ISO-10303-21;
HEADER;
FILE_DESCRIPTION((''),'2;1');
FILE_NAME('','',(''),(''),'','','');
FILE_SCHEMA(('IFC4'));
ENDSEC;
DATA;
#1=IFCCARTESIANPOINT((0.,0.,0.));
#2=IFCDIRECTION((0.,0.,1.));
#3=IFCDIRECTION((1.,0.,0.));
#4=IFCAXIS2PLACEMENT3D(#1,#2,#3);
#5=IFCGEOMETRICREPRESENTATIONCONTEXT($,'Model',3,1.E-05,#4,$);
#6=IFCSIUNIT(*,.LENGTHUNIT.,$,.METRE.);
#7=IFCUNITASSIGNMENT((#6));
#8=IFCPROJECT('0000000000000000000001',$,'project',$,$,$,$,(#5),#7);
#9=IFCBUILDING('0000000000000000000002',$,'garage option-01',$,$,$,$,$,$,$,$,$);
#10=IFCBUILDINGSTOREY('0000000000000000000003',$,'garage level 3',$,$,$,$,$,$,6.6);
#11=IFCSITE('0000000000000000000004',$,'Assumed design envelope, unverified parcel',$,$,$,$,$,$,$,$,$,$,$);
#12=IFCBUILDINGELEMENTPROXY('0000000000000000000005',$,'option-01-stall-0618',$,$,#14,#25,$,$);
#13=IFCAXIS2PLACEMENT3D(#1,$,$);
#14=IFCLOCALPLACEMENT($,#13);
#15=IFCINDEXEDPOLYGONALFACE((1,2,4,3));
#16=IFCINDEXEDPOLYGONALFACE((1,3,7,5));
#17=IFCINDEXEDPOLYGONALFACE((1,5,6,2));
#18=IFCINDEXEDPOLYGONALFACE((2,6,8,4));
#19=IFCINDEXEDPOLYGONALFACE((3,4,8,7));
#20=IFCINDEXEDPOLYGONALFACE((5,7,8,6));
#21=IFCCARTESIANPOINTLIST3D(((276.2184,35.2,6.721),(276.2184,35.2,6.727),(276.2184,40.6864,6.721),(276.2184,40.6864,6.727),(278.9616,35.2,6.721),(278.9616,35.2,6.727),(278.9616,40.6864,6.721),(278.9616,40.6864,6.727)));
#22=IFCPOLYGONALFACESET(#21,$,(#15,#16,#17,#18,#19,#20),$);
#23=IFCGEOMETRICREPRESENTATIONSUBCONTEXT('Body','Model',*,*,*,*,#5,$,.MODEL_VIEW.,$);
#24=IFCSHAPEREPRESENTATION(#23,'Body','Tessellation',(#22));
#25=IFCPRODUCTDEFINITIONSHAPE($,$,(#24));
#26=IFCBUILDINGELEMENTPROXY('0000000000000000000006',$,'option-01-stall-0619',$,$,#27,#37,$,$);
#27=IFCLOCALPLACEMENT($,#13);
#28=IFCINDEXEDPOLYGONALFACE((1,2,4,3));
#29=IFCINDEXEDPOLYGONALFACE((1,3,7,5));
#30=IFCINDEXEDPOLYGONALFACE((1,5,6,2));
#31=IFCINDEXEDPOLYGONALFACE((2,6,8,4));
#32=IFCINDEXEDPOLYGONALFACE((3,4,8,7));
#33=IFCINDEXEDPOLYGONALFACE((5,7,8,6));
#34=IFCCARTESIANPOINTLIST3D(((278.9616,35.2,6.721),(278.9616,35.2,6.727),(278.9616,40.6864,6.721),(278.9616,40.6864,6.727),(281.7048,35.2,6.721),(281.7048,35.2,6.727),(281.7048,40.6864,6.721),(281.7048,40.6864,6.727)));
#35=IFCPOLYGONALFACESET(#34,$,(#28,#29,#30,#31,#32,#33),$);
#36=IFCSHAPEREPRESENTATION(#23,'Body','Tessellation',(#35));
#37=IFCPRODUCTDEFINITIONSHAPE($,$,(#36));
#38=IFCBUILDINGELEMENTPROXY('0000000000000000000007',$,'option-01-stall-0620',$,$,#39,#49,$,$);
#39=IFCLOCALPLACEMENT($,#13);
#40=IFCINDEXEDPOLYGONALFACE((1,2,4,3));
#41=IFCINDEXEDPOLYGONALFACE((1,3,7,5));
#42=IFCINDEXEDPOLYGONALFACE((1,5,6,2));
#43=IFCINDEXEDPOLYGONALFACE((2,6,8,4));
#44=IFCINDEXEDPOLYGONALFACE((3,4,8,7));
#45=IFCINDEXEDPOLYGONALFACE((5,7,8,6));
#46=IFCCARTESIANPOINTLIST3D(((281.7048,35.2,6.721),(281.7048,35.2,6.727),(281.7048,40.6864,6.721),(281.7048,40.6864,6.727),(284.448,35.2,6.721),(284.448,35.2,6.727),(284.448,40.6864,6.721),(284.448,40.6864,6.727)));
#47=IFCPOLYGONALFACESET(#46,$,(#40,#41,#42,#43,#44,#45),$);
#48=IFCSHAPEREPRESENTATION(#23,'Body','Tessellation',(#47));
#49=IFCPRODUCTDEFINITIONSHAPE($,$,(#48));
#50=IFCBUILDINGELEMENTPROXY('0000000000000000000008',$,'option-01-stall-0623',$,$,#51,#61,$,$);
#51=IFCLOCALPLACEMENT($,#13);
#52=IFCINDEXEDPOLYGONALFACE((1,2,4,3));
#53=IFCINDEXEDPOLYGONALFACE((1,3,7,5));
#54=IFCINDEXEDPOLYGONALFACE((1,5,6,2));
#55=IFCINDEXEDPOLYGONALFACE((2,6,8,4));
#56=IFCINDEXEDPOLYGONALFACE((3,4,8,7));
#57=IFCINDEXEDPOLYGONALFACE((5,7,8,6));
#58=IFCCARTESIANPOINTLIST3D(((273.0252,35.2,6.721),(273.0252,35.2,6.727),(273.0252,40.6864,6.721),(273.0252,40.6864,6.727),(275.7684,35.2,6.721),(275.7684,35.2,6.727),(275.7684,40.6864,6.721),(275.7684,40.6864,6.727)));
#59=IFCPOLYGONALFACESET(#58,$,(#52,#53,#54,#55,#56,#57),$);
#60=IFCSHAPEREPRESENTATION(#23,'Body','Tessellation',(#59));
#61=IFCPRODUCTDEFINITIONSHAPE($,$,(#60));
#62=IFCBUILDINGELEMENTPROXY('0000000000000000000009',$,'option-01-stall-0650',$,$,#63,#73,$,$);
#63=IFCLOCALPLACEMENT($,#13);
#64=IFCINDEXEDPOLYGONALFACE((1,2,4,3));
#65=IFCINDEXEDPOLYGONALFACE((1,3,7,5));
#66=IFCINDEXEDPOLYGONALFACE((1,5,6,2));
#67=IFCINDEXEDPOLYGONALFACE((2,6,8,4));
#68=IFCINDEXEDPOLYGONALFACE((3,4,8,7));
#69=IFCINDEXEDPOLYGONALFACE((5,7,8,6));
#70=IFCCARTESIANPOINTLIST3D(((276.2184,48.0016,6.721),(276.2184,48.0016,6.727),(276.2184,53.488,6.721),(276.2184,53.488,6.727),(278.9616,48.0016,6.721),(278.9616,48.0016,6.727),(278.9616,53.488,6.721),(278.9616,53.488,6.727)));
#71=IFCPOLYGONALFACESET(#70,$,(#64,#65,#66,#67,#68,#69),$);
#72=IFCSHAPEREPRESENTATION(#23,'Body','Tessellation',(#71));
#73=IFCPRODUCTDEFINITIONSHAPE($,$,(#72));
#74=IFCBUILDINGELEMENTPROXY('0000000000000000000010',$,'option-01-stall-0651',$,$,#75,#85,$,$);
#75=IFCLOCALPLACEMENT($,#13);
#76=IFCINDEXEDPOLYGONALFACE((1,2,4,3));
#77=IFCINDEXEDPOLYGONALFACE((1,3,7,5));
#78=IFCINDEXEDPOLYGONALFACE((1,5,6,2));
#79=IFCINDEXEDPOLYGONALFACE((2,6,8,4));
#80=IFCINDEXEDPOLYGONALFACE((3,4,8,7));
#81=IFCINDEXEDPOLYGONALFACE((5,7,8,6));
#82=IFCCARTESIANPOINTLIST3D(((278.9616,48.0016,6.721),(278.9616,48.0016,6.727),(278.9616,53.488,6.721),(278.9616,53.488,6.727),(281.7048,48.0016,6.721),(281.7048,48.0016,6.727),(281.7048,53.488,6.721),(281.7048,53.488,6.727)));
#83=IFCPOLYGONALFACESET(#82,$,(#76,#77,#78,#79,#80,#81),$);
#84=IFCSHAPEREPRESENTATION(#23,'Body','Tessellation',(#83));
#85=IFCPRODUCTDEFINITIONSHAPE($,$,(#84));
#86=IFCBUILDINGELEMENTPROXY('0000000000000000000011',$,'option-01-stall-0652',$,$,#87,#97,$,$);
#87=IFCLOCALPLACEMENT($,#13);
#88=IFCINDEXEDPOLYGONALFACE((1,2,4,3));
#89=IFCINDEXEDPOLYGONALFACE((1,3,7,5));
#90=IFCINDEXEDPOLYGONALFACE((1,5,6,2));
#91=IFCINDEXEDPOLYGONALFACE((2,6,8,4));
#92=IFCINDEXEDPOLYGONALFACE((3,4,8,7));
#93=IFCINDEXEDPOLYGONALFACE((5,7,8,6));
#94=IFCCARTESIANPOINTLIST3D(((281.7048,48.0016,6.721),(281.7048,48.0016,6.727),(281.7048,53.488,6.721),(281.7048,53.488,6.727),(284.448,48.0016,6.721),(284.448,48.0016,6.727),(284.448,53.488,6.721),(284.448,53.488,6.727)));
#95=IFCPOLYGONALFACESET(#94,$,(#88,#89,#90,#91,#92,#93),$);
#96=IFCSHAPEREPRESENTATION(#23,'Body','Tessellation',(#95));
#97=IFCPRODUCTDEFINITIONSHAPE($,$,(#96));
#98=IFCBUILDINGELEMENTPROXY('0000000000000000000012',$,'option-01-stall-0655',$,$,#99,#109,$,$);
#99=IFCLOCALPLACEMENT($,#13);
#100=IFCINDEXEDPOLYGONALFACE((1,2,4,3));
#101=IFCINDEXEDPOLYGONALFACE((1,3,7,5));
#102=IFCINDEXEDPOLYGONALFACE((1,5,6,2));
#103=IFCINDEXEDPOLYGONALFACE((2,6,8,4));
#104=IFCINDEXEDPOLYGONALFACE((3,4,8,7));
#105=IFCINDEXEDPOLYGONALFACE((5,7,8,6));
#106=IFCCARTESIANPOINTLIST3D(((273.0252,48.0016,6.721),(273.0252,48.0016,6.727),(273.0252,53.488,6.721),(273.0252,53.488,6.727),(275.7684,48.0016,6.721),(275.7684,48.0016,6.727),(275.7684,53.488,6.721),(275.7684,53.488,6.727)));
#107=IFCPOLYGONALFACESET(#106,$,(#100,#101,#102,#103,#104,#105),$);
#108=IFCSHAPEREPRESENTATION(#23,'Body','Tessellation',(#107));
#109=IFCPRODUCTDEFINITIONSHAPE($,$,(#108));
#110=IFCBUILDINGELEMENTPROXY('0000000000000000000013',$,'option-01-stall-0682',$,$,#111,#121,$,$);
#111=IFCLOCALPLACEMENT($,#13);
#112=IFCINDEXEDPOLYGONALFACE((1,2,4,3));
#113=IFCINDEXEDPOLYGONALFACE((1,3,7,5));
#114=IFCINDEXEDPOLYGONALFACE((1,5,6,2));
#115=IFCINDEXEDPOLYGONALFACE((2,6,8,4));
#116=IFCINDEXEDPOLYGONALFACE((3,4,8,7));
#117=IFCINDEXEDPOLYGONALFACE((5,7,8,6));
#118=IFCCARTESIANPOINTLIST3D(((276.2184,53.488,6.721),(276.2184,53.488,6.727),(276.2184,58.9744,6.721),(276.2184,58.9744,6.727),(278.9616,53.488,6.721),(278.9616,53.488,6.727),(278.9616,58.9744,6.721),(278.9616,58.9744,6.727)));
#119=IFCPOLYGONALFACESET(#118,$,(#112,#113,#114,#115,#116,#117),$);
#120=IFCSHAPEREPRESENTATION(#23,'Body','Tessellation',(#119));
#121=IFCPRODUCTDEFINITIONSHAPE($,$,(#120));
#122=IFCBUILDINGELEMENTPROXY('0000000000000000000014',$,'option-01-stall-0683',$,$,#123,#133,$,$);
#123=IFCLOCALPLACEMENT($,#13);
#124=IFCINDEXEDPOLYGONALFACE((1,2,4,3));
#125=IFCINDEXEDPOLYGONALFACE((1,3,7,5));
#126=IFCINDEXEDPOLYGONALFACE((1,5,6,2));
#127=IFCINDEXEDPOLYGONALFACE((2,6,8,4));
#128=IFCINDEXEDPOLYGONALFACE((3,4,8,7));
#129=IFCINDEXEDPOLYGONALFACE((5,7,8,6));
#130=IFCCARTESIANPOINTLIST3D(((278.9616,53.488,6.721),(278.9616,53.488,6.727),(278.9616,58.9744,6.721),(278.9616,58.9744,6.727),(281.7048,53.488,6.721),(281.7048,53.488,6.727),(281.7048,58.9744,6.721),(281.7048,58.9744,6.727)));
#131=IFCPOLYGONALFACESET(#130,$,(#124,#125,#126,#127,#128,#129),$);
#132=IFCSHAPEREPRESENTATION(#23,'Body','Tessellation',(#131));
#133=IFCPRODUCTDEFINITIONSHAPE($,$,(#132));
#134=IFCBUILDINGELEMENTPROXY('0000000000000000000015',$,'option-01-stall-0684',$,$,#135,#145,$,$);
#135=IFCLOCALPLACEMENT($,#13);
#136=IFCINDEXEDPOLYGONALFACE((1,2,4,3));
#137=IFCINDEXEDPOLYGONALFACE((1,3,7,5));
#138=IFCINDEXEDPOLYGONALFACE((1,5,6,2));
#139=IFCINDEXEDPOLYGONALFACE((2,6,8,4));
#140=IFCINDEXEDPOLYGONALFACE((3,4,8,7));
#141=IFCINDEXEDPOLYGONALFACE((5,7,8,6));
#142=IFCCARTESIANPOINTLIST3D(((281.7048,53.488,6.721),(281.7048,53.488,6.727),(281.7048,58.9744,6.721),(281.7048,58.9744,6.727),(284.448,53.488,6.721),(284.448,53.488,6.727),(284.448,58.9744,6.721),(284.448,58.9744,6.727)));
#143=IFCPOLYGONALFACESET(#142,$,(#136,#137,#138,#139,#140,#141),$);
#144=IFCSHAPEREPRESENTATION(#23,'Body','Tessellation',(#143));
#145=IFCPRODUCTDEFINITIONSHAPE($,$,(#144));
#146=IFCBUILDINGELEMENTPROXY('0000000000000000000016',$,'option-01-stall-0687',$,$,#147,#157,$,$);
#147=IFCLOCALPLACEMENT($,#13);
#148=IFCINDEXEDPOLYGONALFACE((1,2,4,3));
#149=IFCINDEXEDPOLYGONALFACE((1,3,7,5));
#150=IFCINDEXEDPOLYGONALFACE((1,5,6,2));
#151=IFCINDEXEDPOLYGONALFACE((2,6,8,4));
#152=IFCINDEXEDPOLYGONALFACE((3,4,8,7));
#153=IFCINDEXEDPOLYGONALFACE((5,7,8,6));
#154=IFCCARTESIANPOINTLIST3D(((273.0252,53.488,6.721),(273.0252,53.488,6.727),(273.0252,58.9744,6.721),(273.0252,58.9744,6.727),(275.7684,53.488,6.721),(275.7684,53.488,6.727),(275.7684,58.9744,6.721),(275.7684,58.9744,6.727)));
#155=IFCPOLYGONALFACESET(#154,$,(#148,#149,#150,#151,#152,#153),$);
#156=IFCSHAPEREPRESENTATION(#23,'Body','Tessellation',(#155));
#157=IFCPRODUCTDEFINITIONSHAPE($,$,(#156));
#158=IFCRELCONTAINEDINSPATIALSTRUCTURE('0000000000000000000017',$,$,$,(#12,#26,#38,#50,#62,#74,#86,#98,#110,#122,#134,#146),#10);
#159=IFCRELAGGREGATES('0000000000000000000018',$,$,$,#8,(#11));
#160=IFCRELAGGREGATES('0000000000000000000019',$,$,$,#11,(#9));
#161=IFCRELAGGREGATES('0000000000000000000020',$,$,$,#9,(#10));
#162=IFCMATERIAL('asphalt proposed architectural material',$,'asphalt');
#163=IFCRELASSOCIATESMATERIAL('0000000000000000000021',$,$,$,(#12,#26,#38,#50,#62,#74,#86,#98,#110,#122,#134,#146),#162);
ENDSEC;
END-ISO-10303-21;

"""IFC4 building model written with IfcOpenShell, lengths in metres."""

from ifc_helpers import new_model, si_unit, frame, origin_with_axes, place, context, subcontext, project, spatial, rectangle, extrude, material, element, save


model = new_model("IFC4")

# Units and contexts
model_context = context("Model", 3, precision=1e-05, world=origin_with_axes())
body_context = subcontext(model_context, "Body", "Model", "MODEL_VIEW")
ifc_project = project(units=[si_unit("LENGTHUNIT", "METRE")], contexts=[model_context])

# Site, building, storey
site = spatial("IfcSite", under=ifc_project, Name="Assumed design envelope, unverified parcel")
building = spatial("IfcBuilding", under=site, Name="garage option-01")
storey = spatial("IfcBuildingStorey", under=building, Name="garage level 3", Elevation=6.6)

# Building element proxies
ifc_material_1 = material(Name="asphalt proposed architectural material", Category="asphalt")
for number, where, z_axis, x_axis, name in (
    (1, (277.59, 37.9432, 6.721), (0.0, 0.0, 1.0), (1.0, 0.0, 0.0), "option-01-stall-0618"),
    (2, (280.3332, 37.9432, 6.721), (0.0, 0.0, 1.0), (1.0, 0.0, 0.0), "option-01-stall-0619"),
    (3, (283.0764, 37.9432, 6.721), (0.0, 0.0, 1.0), (1.0, 0.0, 0.0), "option-01-stall-0620"),
    (4, (274.3968, 37.9432, 6.721), (0.0, 0.0, 1.0), (1.0, 0.0, 0.0), "option-01-stall-0623"),
    (5, (277.59, 50.7448, 6.721), (0.0, 0.0, 1.0), (1.0, 0.0, 0.0), "option-01-stall-0650"),
    (6, (280.3332, 50.7448, 6.721), (0.0, 0.0, 1.0), (1.0, 0.0, 0.0), "option-01-stall-0651"),
    (7, (283.0764, 50.7448, 6.721), (0.0, 0.0, 1.0), (1.0, 0.0, 0.0), "option-01-stall-0652"),
    (8, (274.3968, 50.7448, 6.721), (0.0, 0.0, 1.0), (1.0, 0.0, 0.0), "option-01-stall-0655"),
):
    element("IfcBuildingElementProxy", number, at=place(None, frame(where, z_axis=z_axis, x_axis=x_axis)), inside=storey, material=ifc_material_1, Name=name, context=body_context, shape_type="SweptSolid", body=[
        extrude(rectangle(XDim=2.7432, YDim=5.4864), origin_with_axes(), (0.0, 0.0, 1.0), 0.006),
    ])
for number, where, z_axis, x_axis, name in (
    (9, (277.59, 56.2312, 6.721), (0.0, 0.0, 1.0), (1.0, 0.0, 0.0), "option-01-stall-0682"),
    (10, (280.3332, 56.2312, 6.721), (0.0, 0.0, 1.0), (1.0, 0.0, 0.0), "option-01-stall-0683"),
    (11, (283.0764, 56.2312, 6.721), (0.0, 0.0, 1.0), (1.0, 0.0, 0.0), "option-01-stall-0684"),
    (12, (274.3968, 56.2312, 6.721), (0.0, 0.0, 1.0), (1.0, 0.0, 0.0), "option-01-stall-0687"),
):
    element("IfcBuildingElementProxy", number, at=place(None, frame(where, z_axis=z_axis, x_axis=x_axis)), inside=storey, material=ifc_material_1, Name=name, context=body_context, shape_type="SweptSolid", body=[
        extrude(rectangle(XDim=2.7432, YDim=5.4864), origin_with_axes(), (0.0, 0.0, 1.0), 0.006),
    ])

save(model, "model.ifc")
